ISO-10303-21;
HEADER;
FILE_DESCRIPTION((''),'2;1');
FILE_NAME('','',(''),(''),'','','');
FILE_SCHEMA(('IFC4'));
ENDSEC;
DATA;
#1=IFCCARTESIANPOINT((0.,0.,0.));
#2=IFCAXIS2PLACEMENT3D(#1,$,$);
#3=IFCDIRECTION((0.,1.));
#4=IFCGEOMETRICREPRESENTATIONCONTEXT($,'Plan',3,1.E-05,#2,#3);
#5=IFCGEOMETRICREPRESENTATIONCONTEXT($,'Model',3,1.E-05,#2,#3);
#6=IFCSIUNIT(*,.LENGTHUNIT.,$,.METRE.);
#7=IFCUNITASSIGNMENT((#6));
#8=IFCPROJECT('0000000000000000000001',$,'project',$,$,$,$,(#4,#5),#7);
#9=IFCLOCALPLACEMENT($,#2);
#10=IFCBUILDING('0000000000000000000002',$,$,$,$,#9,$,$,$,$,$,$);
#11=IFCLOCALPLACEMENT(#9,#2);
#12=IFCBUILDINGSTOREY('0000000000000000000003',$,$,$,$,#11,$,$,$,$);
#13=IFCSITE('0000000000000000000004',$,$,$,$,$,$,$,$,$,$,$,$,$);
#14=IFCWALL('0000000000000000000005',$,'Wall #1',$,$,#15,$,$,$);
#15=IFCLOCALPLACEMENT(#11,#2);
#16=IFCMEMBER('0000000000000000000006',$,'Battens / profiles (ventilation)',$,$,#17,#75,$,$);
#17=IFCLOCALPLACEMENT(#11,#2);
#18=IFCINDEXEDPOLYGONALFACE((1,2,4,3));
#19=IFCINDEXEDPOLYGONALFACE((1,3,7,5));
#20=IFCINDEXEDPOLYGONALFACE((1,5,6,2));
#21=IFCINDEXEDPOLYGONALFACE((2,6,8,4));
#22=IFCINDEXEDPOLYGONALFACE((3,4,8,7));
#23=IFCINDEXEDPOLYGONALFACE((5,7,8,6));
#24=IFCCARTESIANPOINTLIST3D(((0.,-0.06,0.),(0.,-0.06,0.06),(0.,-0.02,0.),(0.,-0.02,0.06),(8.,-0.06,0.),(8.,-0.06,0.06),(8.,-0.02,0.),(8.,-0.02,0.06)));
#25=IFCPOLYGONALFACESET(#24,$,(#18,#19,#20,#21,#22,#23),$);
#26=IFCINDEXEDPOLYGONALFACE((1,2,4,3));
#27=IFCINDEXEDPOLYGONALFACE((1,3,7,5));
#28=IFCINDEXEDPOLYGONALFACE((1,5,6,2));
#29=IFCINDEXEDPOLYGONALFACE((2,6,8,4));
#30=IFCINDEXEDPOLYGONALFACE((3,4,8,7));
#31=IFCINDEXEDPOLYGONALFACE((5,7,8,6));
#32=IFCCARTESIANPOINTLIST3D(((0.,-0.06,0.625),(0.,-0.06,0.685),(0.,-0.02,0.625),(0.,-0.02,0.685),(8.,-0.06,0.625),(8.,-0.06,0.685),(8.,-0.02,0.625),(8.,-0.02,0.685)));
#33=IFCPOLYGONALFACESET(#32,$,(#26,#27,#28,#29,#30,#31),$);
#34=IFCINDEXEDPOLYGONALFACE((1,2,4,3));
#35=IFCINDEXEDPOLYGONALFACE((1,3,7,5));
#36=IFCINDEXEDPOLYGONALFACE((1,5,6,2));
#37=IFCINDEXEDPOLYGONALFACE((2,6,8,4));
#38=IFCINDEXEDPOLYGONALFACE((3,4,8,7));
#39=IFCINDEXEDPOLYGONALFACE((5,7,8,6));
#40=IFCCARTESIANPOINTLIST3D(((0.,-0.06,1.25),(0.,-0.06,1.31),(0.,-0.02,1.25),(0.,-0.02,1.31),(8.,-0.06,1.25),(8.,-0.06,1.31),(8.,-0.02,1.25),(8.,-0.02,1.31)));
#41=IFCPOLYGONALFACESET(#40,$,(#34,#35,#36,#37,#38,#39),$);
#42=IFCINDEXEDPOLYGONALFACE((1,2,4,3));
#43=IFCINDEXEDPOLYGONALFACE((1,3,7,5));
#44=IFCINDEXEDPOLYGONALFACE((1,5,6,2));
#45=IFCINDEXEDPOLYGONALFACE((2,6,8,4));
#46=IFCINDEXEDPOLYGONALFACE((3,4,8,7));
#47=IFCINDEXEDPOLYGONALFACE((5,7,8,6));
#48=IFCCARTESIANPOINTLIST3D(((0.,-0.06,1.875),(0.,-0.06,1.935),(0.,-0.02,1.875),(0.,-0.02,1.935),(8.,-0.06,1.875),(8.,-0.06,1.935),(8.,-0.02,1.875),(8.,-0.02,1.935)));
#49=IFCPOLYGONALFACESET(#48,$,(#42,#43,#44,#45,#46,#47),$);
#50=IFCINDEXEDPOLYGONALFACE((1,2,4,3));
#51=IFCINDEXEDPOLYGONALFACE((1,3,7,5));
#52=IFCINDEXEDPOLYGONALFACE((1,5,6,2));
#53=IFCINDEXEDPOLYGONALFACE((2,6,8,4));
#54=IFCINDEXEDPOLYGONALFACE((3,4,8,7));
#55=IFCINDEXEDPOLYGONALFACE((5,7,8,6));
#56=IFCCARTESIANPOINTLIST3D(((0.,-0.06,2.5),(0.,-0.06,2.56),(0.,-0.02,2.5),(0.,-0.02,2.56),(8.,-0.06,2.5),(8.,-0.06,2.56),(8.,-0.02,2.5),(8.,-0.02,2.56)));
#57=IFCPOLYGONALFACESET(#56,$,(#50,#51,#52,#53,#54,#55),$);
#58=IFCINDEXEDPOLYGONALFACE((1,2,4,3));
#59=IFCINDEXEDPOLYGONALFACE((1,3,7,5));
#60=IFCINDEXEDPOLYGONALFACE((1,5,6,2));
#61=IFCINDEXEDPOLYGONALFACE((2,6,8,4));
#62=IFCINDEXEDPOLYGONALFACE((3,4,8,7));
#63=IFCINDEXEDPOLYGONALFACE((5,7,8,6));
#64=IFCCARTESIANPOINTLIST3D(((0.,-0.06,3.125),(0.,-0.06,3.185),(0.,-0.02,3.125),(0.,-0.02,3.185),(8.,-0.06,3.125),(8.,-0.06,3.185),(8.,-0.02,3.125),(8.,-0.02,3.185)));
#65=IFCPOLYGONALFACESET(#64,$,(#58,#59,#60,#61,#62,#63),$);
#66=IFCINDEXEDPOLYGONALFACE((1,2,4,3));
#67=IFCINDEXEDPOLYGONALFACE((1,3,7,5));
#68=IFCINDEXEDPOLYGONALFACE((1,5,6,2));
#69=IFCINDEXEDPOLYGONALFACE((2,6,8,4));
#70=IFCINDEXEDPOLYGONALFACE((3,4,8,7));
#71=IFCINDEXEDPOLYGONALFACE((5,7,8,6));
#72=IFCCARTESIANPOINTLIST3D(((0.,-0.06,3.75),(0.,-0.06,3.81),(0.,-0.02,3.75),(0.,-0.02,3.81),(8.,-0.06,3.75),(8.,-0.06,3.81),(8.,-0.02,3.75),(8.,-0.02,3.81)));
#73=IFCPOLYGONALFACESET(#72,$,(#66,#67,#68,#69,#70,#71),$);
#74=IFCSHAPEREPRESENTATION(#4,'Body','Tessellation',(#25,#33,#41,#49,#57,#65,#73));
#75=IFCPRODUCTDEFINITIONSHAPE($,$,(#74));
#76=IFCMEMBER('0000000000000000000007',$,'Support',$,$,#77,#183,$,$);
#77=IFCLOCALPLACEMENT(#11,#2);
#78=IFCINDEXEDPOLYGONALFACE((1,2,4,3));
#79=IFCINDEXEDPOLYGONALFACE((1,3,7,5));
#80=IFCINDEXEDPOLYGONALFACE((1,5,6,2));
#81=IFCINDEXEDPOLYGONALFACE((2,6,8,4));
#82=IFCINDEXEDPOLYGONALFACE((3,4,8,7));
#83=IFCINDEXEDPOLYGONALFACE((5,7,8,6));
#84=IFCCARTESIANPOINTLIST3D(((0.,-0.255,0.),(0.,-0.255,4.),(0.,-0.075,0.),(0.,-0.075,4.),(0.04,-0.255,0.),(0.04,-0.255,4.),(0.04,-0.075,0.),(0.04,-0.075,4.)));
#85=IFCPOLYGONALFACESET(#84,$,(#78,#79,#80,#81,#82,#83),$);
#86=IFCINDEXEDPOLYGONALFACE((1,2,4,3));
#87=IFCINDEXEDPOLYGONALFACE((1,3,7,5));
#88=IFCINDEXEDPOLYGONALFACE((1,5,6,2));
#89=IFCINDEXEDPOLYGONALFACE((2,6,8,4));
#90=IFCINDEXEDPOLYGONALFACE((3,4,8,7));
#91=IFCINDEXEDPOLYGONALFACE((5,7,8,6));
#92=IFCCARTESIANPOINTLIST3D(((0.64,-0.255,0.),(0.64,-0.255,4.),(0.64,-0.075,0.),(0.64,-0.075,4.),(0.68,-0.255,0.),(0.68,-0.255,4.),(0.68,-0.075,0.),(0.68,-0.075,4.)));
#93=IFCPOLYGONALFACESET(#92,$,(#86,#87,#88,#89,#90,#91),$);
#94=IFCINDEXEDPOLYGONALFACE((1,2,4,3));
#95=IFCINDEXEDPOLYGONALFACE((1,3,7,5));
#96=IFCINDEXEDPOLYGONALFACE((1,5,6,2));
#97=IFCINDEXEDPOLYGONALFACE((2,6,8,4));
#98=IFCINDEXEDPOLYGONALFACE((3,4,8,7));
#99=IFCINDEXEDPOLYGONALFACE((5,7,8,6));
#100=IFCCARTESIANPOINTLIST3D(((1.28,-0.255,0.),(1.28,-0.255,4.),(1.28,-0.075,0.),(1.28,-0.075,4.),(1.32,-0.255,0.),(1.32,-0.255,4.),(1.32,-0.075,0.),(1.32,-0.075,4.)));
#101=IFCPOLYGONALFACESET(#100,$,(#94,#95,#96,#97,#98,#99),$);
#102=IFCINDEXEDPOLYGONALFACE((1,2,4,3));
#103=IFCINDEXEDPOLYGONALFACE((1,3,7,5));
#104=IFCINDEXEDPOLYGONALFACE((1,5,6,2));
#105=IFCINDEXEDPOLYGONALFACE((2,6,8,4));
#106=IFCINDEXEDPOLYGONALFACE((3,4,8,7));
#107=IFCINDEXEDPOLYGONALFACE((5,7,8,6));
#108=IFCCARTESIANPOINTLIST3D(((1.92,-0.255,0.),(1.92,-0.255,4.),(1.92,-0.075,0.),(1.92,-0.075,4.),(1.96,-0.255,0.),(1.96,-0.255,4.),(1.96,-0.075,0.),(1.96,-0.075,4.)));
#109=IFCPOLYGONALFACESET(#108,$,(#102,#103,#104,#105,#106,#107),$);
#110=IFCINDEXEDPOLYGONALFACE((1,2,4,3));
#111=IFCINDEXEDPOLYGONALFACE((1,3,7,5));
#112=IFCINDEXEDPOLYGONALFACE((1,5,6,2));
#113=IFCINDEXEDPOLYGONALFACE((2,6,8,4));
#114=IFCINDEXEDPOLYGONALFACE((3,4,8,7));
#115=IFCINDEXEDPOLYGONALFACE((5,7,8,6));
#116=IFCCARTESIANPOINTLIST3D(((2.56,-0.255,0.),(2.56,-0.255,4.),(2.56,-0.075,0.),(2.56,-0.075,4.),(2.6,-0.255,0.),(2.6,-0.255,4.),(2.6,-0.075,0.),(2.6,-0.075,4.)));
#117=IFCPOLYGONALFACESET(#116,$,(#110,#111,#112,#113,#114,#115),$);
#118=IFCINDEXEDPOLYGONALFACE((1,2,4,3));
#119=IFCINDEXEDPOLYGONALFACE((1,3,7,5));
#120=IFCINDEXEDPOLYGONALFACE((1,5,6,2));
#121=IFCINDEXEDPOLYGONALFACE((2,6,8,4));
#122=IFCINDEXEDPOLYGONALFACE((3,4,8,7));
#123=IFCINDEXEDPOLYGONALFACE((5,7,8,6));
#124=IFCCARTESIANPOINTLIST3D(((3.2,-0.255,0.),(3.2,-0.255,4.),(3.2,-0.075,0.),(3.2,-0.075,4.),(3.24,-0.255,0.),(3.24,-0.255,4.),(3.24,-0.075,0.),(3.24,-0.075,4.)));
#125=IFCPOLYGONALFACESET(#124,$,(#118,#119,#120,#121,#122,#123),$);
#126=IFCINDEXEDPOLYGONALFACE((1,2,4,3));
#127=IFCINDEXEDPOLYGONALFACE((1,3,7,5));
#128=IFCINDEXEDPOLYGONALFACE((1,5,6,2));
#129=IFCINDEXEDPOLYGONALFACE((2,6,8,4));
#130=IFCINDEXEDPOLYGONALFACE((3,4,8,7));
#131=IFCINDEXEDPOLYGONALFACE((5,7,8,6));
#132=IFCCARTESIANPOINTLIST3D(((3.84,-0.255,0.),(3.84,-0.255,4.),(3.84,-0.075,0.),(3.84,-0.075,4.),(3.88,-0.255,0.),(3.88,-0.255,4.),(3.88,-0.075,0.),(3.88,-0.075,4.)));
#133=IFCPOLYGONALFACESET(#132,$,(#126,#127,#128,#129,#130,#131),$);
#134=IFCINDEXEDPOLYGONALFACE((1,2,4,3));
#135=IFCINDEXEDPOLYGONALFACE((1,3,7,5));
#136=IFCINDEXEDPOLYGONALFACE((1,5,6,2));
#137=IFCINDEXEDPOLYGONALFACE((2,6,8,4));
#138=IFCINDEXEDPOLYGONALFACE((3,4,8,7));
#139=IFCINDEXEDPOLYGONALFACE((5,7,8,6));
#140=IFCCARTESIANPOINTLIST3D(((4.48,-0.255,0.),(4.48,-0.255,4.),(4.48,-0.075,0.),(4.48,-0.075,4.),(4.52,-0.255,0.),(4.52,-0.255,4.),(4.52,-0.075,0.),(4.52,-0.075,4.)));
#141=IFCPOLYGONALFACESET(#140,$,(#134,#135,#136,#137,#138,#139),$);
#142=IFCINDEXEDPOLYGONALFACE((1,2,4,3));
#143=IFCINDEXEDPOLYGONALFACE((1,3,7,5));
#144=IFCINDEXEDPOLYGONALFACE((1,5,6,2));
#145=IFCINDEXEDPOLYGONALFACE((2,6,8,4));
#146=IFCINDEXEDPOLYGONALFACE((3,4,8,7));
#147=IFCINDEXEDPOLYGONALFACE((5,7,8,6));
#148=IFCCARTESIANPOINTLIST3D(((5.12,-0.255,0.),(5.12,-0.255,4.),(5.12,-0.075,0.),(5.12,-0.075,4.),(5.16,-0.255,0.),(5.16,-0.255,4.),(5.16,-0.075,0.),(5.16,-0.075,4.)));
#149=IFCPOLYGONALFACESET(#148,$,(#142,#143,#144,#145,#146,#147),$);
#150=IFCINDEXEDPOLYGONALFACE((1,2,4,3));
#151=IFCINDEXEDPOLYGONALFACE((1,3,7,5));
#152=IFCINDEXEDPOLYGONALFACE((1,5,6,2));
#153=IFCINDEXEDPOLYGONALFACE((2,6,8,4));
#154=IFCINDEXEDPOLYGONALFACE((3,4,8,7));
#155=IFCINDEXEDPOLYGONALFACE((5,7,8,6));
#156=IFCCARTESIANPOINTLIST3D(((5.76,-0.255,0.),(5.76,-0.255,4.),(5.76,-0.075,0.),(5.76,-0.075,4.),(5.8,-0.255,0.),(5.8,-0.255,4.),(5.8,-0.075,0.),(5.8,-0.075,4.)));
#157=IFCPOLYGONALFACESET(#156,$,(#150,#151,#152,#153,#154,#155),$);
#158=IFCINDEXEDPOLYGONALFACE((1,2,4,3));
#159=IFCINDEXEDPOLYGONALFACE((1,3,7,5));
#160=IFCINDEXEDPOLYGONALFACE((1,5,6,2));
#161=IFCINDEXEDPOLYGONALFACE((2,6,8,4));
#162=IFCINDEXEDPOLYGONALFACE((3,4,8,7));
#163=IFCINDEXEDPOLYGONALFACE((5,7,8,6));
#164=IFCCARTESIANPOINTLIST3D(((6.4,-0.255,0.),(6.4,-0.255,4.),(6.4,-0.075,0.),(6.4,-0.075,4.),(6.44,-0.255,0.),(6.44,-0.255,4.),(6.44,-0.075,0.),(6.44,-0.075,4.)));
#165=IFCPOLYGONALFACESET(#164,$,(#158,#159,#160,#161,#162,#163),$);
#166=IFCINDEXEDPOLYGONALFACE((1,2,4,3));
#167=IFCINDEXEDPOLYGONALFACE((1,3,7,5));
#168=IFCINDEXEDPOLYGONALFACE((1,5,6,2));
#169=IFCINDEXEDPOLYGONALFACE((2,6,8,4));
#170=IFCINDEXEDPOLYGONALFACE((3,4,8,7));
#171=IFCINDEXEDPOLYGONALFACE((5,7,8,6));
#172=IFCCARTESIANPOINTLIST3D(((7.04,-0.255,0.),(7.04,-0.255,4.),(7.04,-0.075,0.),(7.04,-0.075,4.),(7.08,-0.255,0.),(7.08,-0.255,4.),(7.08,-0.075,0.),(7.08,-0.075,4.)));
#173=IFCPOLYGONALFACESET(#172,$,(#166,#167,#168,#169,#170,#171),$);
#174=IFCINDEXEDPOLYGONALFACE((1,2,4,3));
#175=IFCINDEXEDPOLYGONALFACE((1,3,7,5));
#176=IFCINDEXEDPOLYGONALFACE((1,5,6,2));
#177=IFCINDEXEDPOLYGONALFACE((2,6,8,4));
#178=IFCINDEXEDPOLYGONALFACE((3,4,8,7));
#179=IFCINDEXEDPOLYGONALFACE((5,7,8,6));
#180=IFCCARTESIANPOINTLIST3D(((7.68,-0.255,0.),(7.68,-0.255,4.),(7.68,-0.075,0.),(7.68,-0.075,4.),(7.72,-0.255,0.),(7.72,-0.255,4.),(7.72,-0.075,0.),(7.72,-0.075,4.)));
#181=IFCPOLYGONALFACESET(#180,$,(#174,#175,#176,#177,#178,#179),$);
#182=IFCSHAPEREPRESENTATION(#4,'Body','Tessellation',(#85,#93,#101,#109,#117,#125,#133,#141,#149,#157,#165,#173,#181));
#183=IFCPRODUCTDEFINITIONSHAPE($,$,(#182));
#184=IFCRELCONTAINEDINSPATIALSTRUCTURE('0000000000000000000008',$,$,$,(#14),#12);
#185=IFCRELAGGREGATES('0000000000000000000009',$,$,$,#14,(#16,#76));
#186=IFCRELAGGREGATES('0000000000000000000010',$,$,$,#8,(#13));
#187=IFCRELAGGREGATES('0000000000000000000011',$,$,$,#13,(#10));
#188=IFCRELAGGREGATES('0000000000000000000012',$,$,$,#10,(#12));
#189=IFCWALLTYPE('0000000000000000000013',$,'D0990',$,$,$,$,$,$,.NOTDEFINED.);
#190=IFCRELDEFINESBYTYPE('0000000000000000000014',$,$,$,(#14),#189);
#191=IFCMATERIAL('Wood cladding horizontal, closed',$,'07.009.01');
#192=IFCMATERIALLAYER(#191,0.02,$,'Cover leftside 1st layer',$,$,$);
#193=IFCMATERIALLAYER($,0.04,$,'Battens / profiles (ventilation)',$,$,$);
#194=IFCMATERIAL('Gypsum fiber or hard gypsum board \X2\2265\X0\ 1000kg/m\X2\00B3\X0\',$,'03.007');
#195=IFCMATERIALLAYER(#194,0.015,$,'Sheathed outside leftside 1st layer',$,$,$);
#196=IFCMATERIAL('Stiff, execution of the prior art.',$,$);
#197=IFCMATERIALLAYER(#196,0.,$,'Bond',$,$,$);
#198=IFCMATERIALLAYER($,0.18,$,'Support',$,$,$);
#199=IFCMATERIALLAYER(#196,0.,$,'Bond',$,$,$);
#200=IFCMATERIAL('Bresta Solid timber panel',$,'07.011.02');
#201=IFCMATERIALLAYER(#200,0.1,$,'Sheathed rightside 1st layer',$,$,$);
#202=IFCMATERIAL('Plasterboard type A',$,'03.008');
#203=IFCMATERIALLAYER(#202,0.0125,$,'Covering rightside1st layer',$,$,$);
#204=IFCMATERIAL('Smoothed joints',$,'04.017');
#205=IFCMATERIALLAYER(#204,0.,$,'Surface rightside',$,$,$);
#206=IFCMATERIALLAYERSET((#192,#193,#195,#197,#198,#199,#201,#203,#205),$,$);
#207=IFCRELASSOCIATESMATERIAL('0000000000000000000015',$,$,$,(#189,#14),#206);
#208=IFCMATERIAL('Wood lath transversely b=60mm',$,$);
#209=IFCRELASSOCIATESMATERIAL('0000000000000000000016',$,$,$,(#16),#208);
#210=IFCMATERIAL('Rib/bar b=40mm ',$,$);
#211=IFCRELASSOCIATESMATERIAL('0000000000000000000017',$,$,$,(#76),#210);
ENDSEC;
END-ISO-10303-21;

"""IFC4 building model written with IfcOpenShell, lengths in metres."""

from ifc_helpers import new_model, si_unit, direction, frame, frame_2d, origin, place, context, project, spatial, rectangle, extrude, material, layer, layer_set, type_object, element, aggregate, save


model = new_model("IFC4")

# Units and contexts
plan_context = context("Plan", 3, precision=1e-05, world=origin(), true_north=direction((0.0, 1.0)))
model_context = context("Model", 3, precision=1e-05, world=origin(), true_north=direction((0.0, 1.0)))
ifc_project = project(units=[si_unit("LENGTHUNIT", "METRE")], contexts=[plan_context, model_context])

# Site, building, storey
site = spatial("IfcSite", under=ifc_project)
building_placement = place(None, origin())
building = spatial("IfcBuilding", under=site, at=building_placement)
storey_placement = place(building_placement, origin())
storey = spatial("IfcBuildingStorey", under=building, at=storey_placement)

# Wall, members
ifc_material_1 = material(Name="Wood cladding horizontal, closed", Category="07.009.01")
ifc_layer_1 = layer(ifc_material_1, 0.02, Name="Cover leftside 1st layer")
ifc_layer_2 = layer(None, 0.04, Name="Battens / profiles (ventilation)")
ifc_material_2 = material(Name="Gypsum fiber or hard gypsum board ≥ 1000kg/m³", Category="03.007")
ifc_layer_3 = layer(ifc_material_2, 0.015, Name="Sheathed outside leftside 1st layer")
ifc_material_3 = material(Name="Stiff, execution of the prior art.")
ifc_layer_4 = layer(ifc_material_3, 0.0, Name="Bond")
ifc_layer_5 = layer(None, 0.18, Name="Support")
ifc_layer_6 = layer(ifc_material_3, 0.0, Name="Bond")
ifc_material_4 = material(Name="Bresta Solid timber panel", Category="07.011.02")
ifc_layer_7 = layer(ifc_material_4, 0.1, Name="Sheathed rightside 1st layer")
ifc_material_5 = material(Name="Plasterboard type A", Category="03.008")
ifc_layer_8 = layer(ifc_material_5, 0.0125, Name="Covering rightside1st layer")
ifc_material_6 = material(Name="Smoothed joints", Category="04.017")
ifc_layer_9 = layer(ifc_material_6, 0.0, Name="Surface rightside")
ifc_layer_set = layer_set([ifc_layer_1, ifc_layer_2, ifc_layer_3, ifc_layer_4, ifc_layer_5, ifc_layer_6, ifc_layer_7, ifc_layer_8, ifc_layer_9])
wall_type = type_object("IfcWallType", Name="D0990", PredefinedType="NOTDEFINED", material=ifc_layer_set)
wall_placement = place(None, frame((0.0, 0.0, 0.0), z_axis=(0.0, -1.0, 0.0), x_axis=(1.0, 0.0, 0.0)))
wall = element("IfcWall", 1, at=wall_placement, inside=storey, type_object=wall_type, material=ifc_layer_set, Name="Wall #1")
ifc_material_7 = material(Name="Wood lath transversely b=60mm")
member_1_placement = place(wall_placement, origin())
member_1 = element("IfcMember", 2, at=member_1_placement, material=ifc_material_7, Name="Battens / profiles (ventilation)", context=plan_context, shape_type="SweptSolid", body=[
    extrude(rectangle(XDim=0.06, YDim=0.04, at=frame_2d((0.03, 0.02), x_axis=(1.0, 0.0))), frame((0.0, 0.0, 0.02), z_axis=(1.0, 0.0, 0.0), x_axis=(0.0, 1.0, 0.0)), (0.0, 0.0, 1.0), 8.0),
    extrude(rectangle(XDim=0.06, YDim=0.04, at=frame_2d((0.03, 0.02), x_axis=(1.0, 0.0))), frame((0.0, 0.625, 0.02), z_axis=(1.0, 0.0, 0.0), x_axis=(0.0, 1.0, 0.0)), (0.0, 0.0, 1.0), 8.0),
    extrude(rectangle(XDim=0.06, YDim=0.04, at=frame_2d((0.03, 0.02), x_axis=(1.0, 0.0))), frame((0.0, 1.25, 0.02), z_axis=(1.0, 0.0, 0.0), x_axis=(0.0, 1.0, 0.0)), (0.0, 0.0, 1.0), 8.0),
    extrude(rectangle(XDim=0.06, YDim=0.04, at=frame_2d((0.03, 0.02), x_axis=(1.0, 0.0))), frame((0.0, 1.875, 0.02), z_axis=(1.0, 0.0, 0.0), x_axis=(0.0, 1.0, 0.0)), (0.0, 0.0, 1.0), 8.0),
    extrude(rectangle(XDim=0.06, YDim=0.04, at=frame_2d((0.03, 0.02), x_axis=(1.0, 0.0))), frame((0.0, 2.5, 0.02), z_axis=(1.0, 0.0, 0.0), x_axis=(0.0, 1.0, 0.0)), (0.0, 0.0, 1.0), 8.0),
    extrude(rectangle(XDim=0.06, YDim=0.04, at=frame_2d((0.03, 0.02), x_axis=(1.0, 0.0))), frame((0.0, 3.125, 0.02), z_axis=(1.0, 0.0, 0.0), x_axis=(0.0, 1.0, 0.0)), (0.0, 0.0, 1.0), 8.0),
    extrude(rectangle(XDim=0.06, YDim=0.04, at=frame_2d((0.03, 0.02), x_axis=(1.0, 0.0))), frame((0.0, 3.75, 0.02), z_axis=(1.0, 0.0, 0.0), x_axis=(0.0, 1.0, 0.0)), (0.0, 0.0, 1.0), 8.0),
])
ifc_material_8 = material(Name="Rib/bar b=40mm ")
member_2_placement = place(wall_placement, origin())
member_2 = element("IfcMember", 3, at=member_2_placement, material=ifc_material_8, Name="Support", context=plan_context, shape_type="SweptSolid", body=[
    extrude(rectangle(XDim=0.04, YDim=0.18, at=frame_2d((0.02, 0.09), x_axis=(1.0, 0.0))), frame((0.0, 4.0, 0.075), z_axis=(0.0, -1.0, 0.0), x_axis=(1.0, 0.0, 0.0)), (0.0, 0.0, 1.0), 4.0),
    extrude(rectangle(XDim=0.04, YDim=0.18, at=frame_2d((0.02, 0.09), x_axis=(1.0, 0.0))), frame((0.64, 4.0, 0.075), z_axis=(0.0, -1.0, 0.0), x_axis=(1.0, 0.0, 0.0)), (0.0, 0.0, 1.0), 4.0),
    extrude(rectangle(XDim=0.04, YDim=0.18, at=frame_2d((0.02, 0.09), x_axis=(1.0, 0.0))), frame((1.28, 4.0, 0.075), z_axis=(0.0, -1.0, 0.0), x_axis=(1.0, 0.0, 0.0)), (0.0, 0.0, 1.0), 4.0),
    extrude(rectangle(XDim=0.04, YDim=0.18, at=frame_2d((0.02, 0.09), x_axis=(1.0, 0.0))), frame((1.92, 4.0, 0.075), z_axis=(0.0, -1.0, 0.0), x_axis=(1.0, 0.0, 0.0)), (0.0, 0.0, 1.0), 4.0),
    extrude(rectangle(XDim=0.04, YDim=0.18, at=frame_2d((0.02, 0.09), x_axis=(1.0, 0.0))), frame((2.56, 4.0, 0.075), z_axis=(0.0, -1.0, 0.0), x_axis=(1.0, 0.0, 0.0)), (0.0, 0.0, 1.0), 4.0),
    extrude(rectangle(XDim=0.04, YDim=0.18, at=frame_2d((0.02, 0.09), x_axis=(1.0, 0.0))), frame((3.2, 4.0, 0.075), z_axis=(0.0, -1.0, 0.0), x_axis=(1.0, 0.0, 0.0)), (0.0, 0.0, 1.0), 4.0),
    extrude(rectangle(XDim=0.04, YDim=0.18, at=frame_2d((0.02, 0.09), x_axis=(1.0, 0.0))), frame((3.84, 4.0, 0.075), z_axis=(0.0, -1.0, 0.0), x_axis=(1.0, 0.0, 0.0)), (0.0, 0.0, 1.0), 4.0),
    extrude(rectangle(XDim=0.04, YDim=0.18, at=frame_2d((0.02, 0.09), x_axis=(1.0, 0.0))), frame((4.48, 4.0, 0.075), z_axis=(0.0, -1.0, 0.0), x_axis=(1.0, 0.0, 0.0)), (0.0, 0.0, 1.0), 4.0),
    extrude(rectangle(XDim=0.04, YDim=0.18, at=frame_2d((0.02, 0.09), x_axis=(1.0, 0.0))), frame((5.12, 4.0, 0.075), z_axis=(0.0, -1.0, 0.0), x_axis=(1.0, 0.0, 0.0)), (0.0, 0.0, 1.0), 4.0),
    extrude(rectangle(XDim=0.04, YDim=0.18, at=frame_2d((0.02, 0.09), x_axis=(1.0, 0.0))), frame((5.76, 4.0, 0.075), z_axis=(0.0, -1.0, 0.0), x_axis=(1.0, 0.0, 0.0)), (0.0, 0.0, 1.0), 4.0),
    extrude(rectangle(XDim=0.04, YDim=0.18, at=frame_2d((0.02, 0.09), x_axis=(1.0, 0.0))), frame((6.4, 4.0, 0.075), z_axis=(0.0, -1.0, 0.0), x_axis=(1.0, 0.0, 0.0)), (0.0, 0.0, 1.0), 4.0),
    extrude(rectangle(XDim=0.04, YDim=0.18, at=frame_2d((0.02, 0.09), x_axis=(1.0, 0.0))), frame((7.04, 4.0, 0.075), z_axis=(0.0, -1.0, 0.0), x_axis=(1.0, 0.0, 0.0)), (0.0, 0.0, 1.0), 4.0),
    extrude(rectangle(XDim=0.04, YDim=0.18, at=frame_2d((0.02, 0.09), x_axis=(1.0, 0.0))), frame((7.68, 4.0, 0.075), z_axis=(0.0, -1.0, 0.0), x_axis=(1.0, 0.0, 0.0)), (0.0, 0.0, 1.0), 4.0),
])
aggregate(wall, [member_1, member_2])

save(model, "model.ifc")
